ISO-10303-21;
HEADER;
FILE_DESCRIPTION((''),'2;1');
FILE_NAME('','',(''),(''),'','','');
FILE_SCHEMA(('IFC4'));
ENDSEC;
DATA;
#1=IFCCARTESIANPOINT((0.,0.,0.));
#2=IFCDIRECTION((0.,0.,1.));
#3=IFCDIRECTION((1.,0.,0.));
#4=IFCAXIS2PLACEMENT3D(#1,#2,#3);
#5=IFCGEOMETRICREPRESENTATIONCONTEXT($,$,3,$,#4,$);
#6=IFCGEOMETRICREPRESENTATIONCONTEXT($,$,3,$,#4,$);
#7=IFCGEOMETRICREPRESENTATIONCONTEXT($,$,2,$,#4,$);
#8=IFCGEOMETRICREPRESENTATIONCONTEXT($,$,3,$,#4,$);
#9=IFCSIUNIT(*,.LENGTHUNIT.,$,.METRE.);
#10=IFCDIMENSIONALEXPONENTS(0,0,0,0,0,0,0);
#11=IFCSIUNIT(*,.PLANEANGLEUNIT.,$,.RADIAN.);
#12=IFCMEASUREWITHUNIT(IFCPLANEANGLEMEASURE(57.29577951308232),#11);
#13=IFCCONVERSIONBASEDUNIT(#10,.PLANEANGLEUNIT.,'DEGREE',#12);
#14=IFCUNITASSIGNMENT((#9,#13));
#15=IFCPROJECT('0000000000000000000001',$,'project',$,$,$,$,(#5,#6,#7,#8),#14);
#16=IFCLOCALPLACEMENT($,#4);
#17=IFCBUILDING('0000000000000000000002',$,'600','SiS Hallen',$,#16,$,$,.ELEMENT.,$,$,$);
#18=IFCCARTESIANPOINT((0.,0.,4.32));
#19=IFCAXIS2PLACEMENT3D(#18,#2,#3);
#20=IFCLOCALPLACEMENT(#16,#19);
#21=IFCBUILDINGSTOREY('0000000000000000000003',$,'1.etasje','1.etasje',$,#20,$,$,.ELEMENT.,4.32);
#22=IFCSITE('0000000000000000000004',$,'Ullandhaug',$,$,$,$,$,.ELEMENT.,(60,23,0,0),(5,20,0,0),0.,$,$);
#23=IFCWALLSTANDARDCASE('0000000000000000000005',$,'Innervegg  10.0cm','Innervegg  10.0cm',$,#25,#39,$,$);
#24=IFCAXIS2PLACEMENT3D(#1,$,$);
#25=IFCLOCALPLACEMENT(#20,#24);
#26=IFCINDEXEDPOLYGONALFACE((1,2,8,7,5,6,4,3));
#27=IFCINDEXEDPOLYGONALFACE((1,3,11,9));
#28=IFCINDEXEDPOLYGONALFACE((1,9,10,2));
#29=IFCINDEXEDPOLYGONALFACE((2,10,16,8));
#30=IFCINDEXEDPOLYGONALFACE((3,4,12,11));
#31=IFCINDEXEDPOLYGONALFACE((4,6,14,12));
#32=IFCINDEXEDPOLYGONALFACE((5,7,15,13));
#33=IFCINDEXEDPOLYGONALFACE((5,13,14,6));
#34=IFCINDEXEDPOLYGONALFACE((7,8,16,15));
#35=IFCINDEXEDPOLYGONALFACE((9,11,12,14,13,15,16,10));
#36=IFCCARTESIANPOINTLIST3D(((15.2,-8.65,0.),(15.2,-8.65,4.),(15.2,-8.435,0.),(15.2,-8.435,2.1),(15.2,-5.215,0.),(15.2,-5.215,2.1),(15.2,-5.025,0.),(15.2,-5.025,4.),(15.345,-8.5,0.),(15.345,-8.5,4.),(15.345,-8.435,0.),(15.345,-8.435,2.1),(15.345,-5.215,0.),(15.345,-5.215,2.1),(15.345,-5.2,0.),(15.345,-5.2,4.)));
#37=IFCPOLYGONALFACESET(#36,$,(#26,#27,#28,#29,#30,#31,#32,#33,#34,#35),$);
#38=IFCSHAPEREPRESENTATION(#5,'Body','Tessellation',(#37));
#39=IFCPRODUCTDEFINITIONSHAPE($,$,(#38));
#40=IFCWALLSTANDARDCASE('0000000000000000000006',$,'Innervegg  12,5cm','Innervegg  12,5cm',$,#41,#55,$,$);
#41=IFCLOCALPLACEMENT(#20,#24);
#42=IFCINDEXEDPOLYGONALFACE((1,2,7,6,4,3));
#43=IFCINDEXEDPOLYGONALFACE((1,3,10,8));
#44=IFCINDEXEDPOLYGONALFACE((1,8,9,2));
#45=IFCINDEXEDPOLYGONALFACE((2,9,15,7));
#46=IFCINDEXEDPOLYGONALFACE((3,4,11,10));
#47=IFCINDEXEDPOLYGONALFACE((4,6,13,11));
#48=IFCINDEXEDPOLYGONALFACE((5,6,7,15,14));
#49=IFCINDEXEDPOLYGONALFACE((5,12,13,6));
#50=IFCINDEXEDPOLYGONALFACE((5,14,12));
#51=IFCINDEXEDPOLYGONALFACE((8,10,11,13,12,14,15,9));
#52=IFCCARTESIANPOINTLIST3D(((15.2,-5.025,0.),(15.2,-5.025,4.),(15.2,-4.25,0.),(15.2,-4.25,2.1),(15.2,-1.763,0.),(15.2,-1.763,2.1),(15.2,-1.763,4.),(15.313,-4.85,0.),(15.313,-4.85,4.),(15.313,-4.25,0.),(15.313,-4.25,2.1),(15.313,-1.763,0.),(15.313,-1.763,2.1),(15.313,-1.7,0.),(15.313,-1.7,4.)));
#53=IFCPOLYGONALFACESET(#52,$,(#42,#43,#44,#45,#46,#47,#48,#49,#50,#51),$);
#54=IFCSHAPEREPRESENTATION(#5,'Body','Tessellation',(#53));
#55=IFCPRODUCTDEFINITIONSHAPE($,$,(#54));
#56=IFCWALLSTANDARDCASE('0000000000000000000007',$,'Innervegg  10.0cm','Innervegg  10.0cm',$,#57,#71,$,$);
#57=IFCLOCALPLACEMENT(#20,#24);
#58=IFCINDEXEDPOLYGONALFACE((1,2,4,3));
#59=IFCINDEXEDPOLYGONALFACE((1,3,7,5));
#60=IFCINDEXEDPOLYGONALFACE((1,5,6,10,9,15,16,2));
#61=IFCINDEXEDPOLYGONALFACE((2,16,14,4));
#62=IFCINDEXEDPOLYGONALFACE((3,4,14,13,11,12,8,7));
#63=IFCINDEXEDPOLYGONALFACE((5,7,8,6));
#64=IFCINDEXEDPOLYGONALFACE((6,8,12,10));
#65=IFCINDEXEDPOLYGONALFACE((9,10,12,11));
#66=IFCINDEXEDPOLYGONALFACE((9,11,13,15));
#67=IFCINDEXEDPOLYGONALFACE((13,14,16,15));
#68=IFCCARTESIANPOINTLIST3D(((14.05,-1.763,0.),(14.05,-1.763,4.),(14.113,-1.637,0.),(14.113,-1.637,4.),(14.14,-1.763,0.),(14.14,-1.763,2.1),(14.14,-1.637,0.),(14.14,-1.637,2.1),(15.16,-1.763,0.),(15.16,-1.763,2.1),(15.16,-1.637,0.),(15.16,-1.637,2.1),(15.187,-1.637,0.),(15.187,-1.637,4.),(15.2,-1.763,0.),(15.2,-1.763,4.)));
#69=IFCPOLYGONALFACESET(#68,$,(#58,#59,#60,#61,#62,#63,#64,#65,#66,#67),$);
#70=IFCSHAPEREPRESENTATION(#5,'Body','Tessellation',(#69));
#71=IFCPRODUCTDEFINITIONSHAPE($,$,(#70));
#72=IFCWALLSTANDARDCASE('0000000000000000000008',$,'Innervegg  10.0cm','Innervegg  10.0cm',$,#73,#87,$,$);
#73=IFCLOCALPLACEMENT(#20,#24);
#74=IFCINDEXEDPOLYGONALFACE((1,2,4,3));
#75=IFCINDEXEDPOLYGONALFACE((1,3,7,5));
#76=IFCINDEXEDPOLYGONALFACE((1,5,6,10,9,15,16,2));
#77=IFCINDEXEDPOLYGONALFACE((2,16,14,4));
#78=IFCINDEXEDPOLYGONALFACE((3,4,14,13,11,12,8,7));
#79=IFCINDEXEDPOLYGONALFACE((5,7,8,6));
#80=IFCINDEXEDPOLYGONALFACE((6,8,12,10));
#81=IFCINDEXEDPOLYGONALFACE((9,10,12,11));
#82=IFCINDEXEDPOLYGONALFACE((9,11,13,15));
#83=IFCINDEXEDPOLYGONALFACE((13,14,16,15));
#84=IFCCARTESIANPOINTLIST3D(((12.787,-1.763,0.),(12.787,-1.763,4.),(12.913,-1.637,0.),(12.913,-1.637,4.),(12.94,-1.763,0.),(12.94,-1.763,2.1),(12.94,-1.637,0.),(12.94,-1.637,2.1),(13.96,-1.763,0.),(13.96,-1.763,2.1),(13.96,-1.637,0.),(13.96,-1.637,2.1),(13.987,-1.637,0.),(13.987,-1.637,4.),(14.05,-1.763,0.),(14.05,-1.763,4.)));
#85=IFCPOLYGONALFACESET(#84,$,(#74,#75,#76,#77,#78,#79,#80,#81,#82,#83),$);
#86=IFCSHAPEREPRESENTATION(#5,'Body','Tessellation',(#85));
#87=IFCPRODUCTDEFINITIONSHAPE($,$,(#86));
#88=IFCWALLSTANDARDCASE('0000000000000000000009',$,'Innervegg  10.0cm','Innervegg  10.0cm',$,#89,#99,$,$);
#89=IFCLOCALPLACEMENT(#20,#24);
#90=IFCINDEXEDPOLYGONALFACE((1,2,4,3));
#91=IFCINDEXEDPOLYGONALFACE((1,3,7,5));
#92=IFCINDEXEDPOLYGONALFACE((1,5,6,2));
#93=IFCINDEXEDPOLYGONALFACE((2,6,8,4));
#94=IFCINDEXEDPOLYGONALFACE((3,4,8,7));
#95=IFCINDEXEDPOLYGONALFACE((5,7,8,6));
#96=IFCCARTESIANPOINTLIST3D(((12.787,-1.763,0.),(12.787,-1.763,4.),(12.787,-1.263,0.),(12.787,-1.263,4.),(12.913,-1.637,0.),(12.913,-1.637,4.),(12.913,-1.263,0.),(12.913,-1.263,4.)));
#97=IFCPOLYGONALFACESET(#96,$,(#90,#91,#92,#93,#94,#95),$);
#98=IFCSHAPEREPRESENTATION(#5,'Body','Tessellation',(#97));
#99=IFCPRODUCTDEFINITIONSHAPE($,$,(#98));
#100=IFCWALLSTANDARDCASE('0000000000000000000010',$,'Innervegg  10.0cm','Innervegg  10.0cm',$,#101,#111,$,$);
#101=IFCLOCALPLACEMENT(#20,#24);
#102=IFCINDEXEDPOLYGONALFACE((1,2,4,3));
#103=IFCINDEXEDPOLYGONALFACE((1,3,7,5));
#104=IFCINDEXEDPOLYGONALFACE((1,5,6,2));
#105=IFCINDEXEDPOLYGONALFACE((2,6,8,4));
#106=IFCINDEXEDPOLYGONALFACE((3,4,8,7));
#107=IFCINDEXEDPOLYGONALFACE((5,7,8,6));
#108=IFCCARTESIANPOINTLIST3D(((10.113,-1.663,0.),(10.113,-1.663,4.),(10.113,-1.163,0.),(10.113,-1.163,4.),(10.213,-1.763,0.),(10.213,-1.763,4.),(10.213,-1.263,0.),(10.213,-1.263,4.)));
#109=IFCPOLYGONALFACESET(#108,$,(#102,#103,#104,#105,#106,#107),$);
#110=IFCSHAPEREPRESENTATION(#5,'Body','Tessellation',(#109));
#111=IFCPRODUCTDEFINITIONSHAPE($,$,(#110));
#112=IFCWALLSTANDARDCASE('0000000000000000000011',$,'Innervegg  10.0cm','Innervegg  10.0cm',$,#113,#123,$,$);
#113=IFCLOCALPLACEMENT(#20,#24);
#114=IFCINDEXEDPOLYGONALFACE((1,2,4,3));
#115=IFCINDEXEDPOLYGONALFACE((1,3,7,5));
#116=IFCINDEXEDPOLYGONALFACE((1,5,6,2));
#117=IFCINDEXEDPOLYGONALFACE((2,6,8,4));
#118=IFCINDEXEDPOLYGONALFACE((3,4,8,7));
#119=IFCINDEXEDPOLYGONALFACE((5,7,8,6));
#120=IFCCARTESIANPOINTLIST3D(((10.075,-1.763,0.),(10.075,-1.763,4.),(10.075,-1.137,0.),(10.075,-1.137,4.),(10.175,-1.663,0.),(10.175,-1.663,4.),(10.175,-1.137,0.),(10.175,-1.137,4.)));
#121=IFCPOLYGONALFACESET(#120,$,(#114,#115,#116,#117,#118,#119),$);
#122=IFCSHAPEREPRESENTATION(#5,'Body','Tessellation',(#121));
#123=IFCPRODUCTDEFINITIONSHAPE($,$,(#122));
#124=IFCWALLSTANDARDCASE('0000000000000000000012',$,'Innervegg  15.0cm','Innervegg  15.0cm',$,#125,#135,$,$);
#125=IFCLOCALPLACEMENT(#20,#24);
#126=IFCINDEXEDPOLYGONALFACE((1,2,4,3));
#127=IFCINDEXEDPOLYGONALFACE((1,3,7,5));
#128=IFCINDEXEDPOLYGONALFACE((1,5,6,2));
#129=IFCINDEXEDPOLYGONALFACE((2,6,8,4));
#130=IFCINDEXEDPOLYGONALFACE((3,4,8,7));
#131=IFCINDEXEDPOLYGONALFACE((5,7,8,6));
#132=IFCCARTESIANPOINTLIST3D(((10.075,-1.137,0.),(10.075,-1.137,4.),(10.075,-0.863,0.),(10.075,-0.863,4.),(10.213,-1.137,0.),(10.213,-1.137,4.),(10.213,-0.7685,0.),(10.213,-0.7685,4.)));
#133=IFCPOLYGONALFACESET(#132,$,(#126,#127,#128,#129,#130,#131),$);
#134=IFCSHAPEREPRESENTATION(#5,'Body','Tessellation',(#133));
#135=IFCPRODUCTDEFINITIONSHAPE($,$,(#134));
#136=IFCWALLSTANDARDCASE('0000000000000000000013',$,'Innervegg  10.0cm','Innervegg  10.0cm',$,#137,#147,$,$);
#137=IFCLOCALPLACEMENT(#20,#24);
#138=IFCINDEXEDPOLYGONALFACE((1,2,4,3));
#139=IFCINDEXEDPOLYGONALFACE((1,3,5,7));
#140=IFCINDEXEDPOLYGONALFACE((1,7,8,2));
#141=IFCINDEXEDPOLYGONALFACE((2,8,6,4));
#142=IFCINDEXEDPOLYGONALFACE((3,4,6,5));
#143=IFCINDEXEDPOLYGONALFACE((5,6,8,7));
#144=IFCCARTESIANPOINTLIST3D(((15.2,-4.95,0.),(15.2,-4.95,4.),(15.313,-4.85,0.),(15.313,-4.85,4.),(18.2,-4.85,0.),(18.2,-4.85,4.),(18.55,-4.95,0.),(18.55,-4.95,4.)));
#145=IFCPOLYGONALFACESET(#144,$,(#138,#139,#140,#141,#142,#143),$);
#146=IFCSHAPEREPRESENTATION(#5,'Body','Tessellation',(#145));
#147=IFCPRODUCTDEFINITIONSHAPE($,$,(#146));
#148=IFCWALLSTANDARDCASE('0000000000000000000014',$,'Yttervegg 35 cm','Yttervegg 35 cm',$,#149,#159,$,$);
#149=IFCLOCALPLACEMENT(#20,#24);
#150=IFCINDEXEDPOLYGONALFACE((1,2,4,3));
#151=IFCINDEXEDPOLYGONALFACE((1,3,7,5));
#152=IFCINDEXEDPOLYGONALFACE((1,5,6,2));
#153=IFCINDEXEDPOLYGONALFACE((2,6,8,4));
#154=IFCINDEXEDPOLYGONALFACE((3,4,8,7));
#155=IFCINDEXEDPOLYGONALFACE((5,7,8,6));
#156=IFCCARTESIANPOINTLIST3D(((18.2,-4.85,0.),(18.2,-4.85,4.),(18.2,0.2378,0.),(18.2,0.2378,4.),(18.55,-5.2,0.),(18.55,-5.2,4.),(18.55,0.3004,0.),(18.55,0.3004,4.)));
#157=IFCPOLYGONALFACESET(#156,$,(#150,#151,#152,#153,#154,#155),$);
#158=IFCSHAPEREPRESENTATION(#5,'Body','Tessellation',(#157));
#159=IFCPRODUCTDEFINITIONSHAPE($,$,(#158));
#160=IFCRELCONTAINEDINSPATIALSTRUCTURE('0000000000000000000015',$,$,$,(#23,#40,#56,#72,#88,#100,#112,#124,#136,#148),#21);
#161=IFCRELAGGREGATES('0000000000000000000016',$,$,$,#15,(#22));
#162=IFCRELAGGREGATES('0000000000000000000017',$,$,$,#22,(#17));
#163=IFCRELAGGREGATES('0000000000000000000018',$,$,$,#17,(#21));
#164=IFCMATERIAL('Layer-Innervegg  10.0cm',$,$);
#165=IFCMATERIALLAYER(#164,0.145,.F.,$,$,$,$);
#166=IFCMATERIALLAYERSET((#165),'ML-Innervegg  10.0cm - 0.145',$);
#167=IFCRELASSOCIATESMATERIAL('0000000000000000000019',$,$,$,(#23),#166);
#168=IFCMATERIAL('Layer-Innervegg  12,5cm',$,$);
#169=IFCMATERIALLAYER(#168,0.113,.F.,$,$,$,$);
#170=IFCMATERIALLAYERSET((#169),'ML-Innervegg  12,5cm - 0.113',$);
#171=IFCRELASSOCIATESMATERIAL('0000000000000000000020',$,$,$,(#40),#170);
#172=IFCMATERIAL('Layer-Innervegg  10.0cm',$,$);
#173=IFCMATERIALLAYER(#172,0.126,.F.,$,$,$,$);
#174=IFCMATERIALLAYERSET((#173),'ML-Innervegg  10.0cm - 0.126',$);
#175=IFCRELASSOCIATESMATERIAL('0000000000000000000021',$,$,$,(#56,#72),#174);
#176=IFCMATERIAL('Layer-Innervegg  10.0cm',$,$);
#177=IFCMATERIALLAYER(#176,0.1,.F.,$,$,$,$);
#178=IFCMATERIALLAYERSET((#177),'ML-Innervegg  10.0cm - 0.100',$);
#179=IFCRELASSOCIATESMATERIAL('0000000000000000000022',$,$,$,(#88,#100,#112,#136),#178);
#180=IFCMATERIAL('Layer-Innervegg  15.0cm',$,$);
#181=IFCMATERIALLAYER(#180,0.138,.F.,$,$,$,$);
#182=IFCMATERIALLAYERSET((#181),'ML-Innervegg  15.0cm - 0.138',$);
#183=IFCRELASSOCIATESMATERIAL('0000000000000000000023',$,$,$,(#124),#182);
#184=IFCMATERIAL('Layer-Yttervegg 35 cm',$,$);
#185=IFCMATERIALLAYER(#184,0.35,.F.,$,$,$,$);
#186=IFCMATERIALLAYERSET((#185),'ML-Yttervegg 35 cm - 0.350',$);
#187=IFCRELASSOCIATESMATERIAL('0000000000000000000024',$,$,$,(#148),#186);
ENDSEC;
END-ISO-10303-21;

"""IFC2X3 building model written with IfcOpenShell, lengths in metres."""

from ifc_helpers import new_model, entity, si_unit, converted_unit, frame, origin_with_axes, place, context, project, spatial, polyline, outline, extrude, material, layer, layer_set, layer_usage, element, save


model = new_model("IFC2X3")

# Units and contexts
context_of_model_1 = context(None, 3, world=origin_with_axes())
context_of_model_2 = context(None, 3, world=origin_with_axes())
context_of_model_3 = context(None, 2, world=origin_with_axes())
context_of_model_4 = context(None, 3, world=origin_with_axes())
ifc_project = project(units=[si_unit("LENGTHUNIT", "METRE"), converted_unit("PLANEANGLEUNIT", "DEGREE", entity("IfcPlaneAngleMeasure", 57.29577951308232), si_unit("PLANEANGLEUNIT", "RADIAN"), dimensions=[0, 0, 0, 0, 0, 0, 0])], contexts=[context_of_model_1, context_of_model_2, context_of_model_3, context_of_model_4])

# Site, building, storey
site = spatial("IfcSite", under=ifc_project, Name="Ullandhaug", CompositionType="ELEMENT", RefLatitude=(60, 23, 0, 0), RefLongitude=(5, 20, 0, 0), RefElevation=0.0)
building_placement = place(None, origin_with_axes())
building = spatial("IfcBuilding", under=site, at=building_placement, Name="600", Description="SiS Hallen", CompositionType="ELEMENT")
storey_placement = place(building_placement, frame((0.0, 0.0, 4.32), z_axis=(0.0, 0.0, 1.0), x_axis=(1.0, 0.0, 0.0)))
storey = spatial("IfcBuildingStorey", under=building, at=storey_placement, Name="1.etasje", Description="1.etasje", CompositionType="ELEMENT", Elevation=4.32)

# Shared definitions
ifc_material_1 = material(Name="Layer-Innervegg  10.0cm")
ifc_layer_1 = layer(ifc_material_1, 0.1, ventilated=False)
ifc_layer_set_1 = layer_set([ifc_layer_1], Name="ML-Innervegg  10.0cm - 0.100")
ifc_layer_usage_1 = layer_usage(ifc_layer_set_1, "AXIS2", "POSITIVE", 0.0)

# Walls, openings
ifc_material_2 = material(Name="Layer-Innervegg  10.0cm")
ifc_layer_2 = layer(ifc_material_2, 0.145, ventilated=False)
ifc_layer_set_2 = layer_set([ifc_layer_2], Name="ML-Innervegg  10.0cm - 0.145")
ifc_layer_usage_2 = layer_usage(ifc_layer_set_2, "AXIS2", "POSITIVE", 0.0)
wall_1_placement = place(storey_placement, frame((15.345, -8.5, 0.0), z_axis=(0.0, 0.0, 1.0), x_axis=(0.0, 1.0, 0.0)))
wall_1 = element("IfcWallStandardCase", 1, at=wall_1_placement, inside=storey, material=ifc_layer_usage_2, Name="Innervegg  10.0cm", Description="Innervegg  10.0cm", context=context_of_model_1, shape_type="SweptSolid", body=[
    extrude(outline(polyline([(0.0, 0.0), (3.3, 0.0), (3.475, 0.145), (-0.15, 0.145), (0.0, 0.0)])), frame((0.0, 0.0, 0.0), z_axis=(0.0, 0.0, 1.0), x_axis=(1.0, 0.0, 0.0)), (0.0, 0.0, 1.0), 4.0),
])
opening_1_placement = place(wall_1_placement, frame((0.065, 0.145, 0.0), z_axis=(0.0, 0.0, 1.0), x_axis=(1.0, 0.0, 0.0)))
element("IfcOpeningElement", 2, at=opening_1_placement, cuts=wall_1, context=context_of_model_1, shape_type="SweptSolid", body=[
    extrude(outline(polyline([(0.0, 0.0), (2.1, 0.0), (2.1, 3.22), (0.0, 3.22), (0.0, 0.0)])), frame((0.0, 0.0, 0.0), z_axis=(0.0, 1.0, 0.0), x_axis=(0.0, 0.0, 1.0)), (0.0, 0.0, -1.0), 0.145),
])
ifc_material_3 = material(Name="Layer-Innervegg  12,5cm")
ifc_layer_3 = layer(ifc_material_3, 0.113, ventilated=False)
ifc_layer_set_3 = layer_set([ifc_layer_3], Name="ML-Innervegg  12,5cm - 0.113")
ifc_layer_usage_3 = layer_usage(ifc_layer_set_3, "AXIS2", "POSITIVE", 0.0)
wall_2_placement = place(storey_placement, frame((15.313, -4.85, 0.0), z_axis=(0.0, 0.0, 1.0), x_axis=(0.0, 1.0, 0.0)))
wall_2 = element("IfcWallStandardCase", 3, at=wall_2_placement, inside=storey, material=ifc_layer_usage_3, Name="Innervegg  12,5cm", Description="Innervegg  12,5cm", context=context_of_model_1, shape_type="SweptSolid", body=[
    extrude(outline(polyline([(0.0, 0.0), (3.15, 0.0), (3.087, 0.113), (-0.175, 0.113), (0.0, 0.0)])), frame((0.0, 0.0, 0.0), z_axis=(0.0, 0.0, 1.0), x_axis=(1.0, 0.0, 0.0)), (0.0, 0.0, 1.0), 4.0),
])
opening_2_placement = place(wall_2_placement, frame((0.6, 0.113, 0.0), z_axis=(0.0, 0.0, 1.0), x_axis=(1.0, 0.0, 0.0)))
element("IfcOpeningElement", 4, at=opening_2_placement, cuts=wall_2, context=context_of_model_1, shape_type="SweptSolid", body=[
    extrude(outline(polyline([(0.0, 0.0), (2.1, 0.0), (2.1, 2.487), (0.0, 2.487), (0.0, 0.0)])), frame((0.0, 0.0, 0.0), z_axis=(0.0, 1.0, 0.0), x_axis=(0.0, 0.0, 1.0)), (0.0, 0.0, -1.0), 0.113),
])
ifc_material_4 = material(Name="Layer-Innervegg  10.0cm")
ifc_layer_4 = layer(ifc_material_4, 0.126, ventilated=False)
ifc_layer_set_4 = layer_set([ifc_layer_4], Name="ML-Innervegg  10.0cm - 0.126")
ifc_layer_usage_4 = layer_usage(ifc_layer_set_4, "AXIS2", "POSITIVE", 0.0)
wall_3_placement = place(storey_placement, frame((15.187, -1.637, 0.0), z_axis=(0.0, 0.0, 1.0), x_axis=(-1.0, 0.0, 0.0)))
wall_3 = element("IfcWallStandardCase", 5, at=wall_3_placement, inside=storey, material=ifc_layer_usage_4, Name="Innervegg  10.0cm", Description="Innervegg  10.0cm", context=context_of_model_1, shape_type="SweptSolid", body=[
    extrude(outline(polyline([(0.0, 0.0), (1.074, 0.0), (1.137, 0.126), (-0.013, 0.126), (0.0, 0.0)])), frame((0.0, 0.0, 0.0), z_axis=(0.0, 0.0, 1.0), x_axis=(1.0, 0.0, 0.0)), (0.0, 0.0, 1.0), 4.0),
])
opening_3_placement = place(wall_3_placement, frame((0.027, 0.126, 0.0), z_axis=(0.0, 0.0, 1.0), x_axis=(1.0, 0.0, 0.0)))
element("IfcOpeningElement", 6, at=opening_3_placement, cuts=wall_3, context=context_of_model_1, shape_type="SweptSolid", body=[
    extrude(outline(polyline([(0.0, 0.0), (2.1, 0.0), (2.1, 1.02), (0.0, 1.02), (0.0, 0.0)])), frame((0.0, 0.0, 0.0), z_axis=(0.0, 1.0, 0.0), x_axis=(0.0, 0.0, 1.0)), (0.0, 0.0, -1.0), 0.126),
])
wall_4_placement = place(storey_placement, frame((13.987, -1.637, 0.0), z_axis=(0.0, 0.0, 1.0), x_axis=(-1.0, 0.0, 0.0)))
wall_4 = element("IfcWallStandardCase", 7, at=wall_4_placement, inside=storey, material=ifc_layer_usage_4, Name="Innervegg  10.0cm", Description="Innervegg  10.0cm", context=context_of_model_1, shape_type="SweptSolid", body=[
    extrude(outline(polyline([(0.0, 0.0), (1.074, 0.0), (1.2, 0.126), (-0.063, 0.126), (0.0, 0.0)])), frame((0.0, 0.0, 0.0), z_axis=(0.0, 0.0, 1.0), x_axis=(1.0, 0.0, 0.0)), (0.0, 0.0, 1.0), 4.0),
])
opening_4_placement = place(wall_4_placement, frame((0.027, 0.126, 0.0), z_axis=(0.0, 0.0, 1.0), x_axis=(1.0, 0.0, 0.0)))
element("IfcOpeningElement", 8, at=opening_4_placement, cuts=wall_4, context=context_of_model_1, shape_type="SweptSolid", body=[
    extrude(outline(polyline([(0.0, 0.0), (2.1, 0.0), (2.1, 1.02), (0.0, 1.02), (0.0, 0.0)])), frame((0.0, 0.0, 0.0), z_axis=(0.0, 1.0, 0.0), x_axis=(0.0, 0.0, 1.0)), (0.0, 0.0, -1.0), 0.126),
])

# Walls
wall_5_placement = place(storey_placement, frame((12.913, -1.637, 0.0), z_axis=(0.0, 0.0, 1.0), x_axis=(0.0, 1.0, 0.0)))
element("IfcWallStandardCase", 9, at=wall_5_placement, inside=storey, material=ifc_layer_usage_1, Name="Innervegg  10.0cm", Description="Innervegg  10.0cm", context=context_of_model_1, shape_type="SweptSolid", body=[
    extrude(outline(polyline([(0.0, 0.0), (0.374, 0.0), (0.374, 0.126), (-0.126, 0.126), (0.0, 0.0)])), frame((0.0, 0.0, 0.0), z_axis=(0.0, 0.0, 1.0), x_axis=(1.0, 0.0, 0.0)), (0.0, 0.0, 1.0), 4.0),
])
wall_6_placement = place(storey_placement, frame((10.113, -1.163, 0.0), z_axis=(0.0, 0.0, 1.0), x_axis=(0.0, -1.0, 0.0)))
element("IfcWallStandardCase", 10, at=wall_6_placement, inside=storey, material=ifc_layer_usage_1, Name="Innervegg  10.0cm", Description="Innervegg  10.0cm", context=context_of_model_1, shape_type="SweptSolid", body=[
    extrude(outline(polyline([(0.0, 0.0), (0.5, 0.0), (0.6, 0.1), (0.1, 0.1), (0.0, 0.0)])), frame((0.0, 0.0, 0.0), z_axis=(0.0, 0.0, 1.0), x_axis=(1.0, 0.0, 0.0)), (0.0, 0.0, 1.0), 4.0),
])
wall_7_placement = place(storey_placement, frame((10.175, -1.663, 0.0), z_axis=(0.0, 0.0, 1.0), x_axis=(0.0, 1.0, 0.0)))
element("IfcWallStandardCase", 11, at=wall_7_placement, inside=storey, material=ifc_layer_usage_1, Name="Innervegg  10.0cm", Description="Innervegg  10.0cm", context=context_of_model_1, shape_type="SweptSolid", body=[
    extrude(outline(polyline([(0.0, 0.0), (0.526, 0.0), (0.526, 0.1), (-0.1, 0.1), (0.0, 0.0)])), frame((0.0, 0.0, 0.0), z_axis=(0.0, 0.0, 1.0), x_axis=(1.0, 0.0, 0.0)), (0.0, 0.0, 1.0), 4.0),
])
ifc_material_5 = material(Name="Layer-Innervegg  15.0cm")
ifc_layer_5 = layer(ifc_material_5, 0.138, ventilated=False)
ifc_layer_set_5 = layer_set([ifc_layer_5], Name="ML-Innervegg  15.0cm - 0.138")
ifc_layer_usage_5 = layer_usage(ifc_layer_set_5, "AXIS2", "POSITIVE", 0.0)
wall_8_placement = place(storey_placement, frame((10.213, -1.137, 0.0), z_axis=(0.0, 0.0, 1.0), x_axis=(0.0, 1.0, 0.0)))
element("IfcWallStandardCase", 12, at=wall_8_placement, inside=storey, material=ifc_layer_usage_5, Name="Innervegg  15.0cm", Description="Innervegg  15.0cm", context=context_of_model_1, shape_type="SweptSolid", body=[
    extrude(outline(polyline([(0.0, 0.0), (0.3685, 0.0), (0.274, 0.138), (0.0, 0.138), (0.0, 0.0)])), frame((0.0, 0.0, 0.0), z_axis=(0.0, 0.0, 1.0), x_axis=(1.0, 0.0, 0.0)), (0.0, 0.0, 1.0), 4.0),
])
wall_9_placement = place(storey_placement, frame((15.2, -4.95, 0.0), z_axis=(0.0, 0.0, 1.0), x_axis=(1.0, 0.0, 0.0)))
element("IfcWallStandardCase", 13, at=wall_9_placement, inside=storey, material=ifc_layer_usage_1, Name="Innervegg  10.0cm", Description="Innervegg  10.0cm", context=context_of_model_1, shape_type="SweptSolid", body=[
    extrude(outline(polyline([(0.0, 0.0), (3.35, 0.0), (3.0, 0.1), (0.113, 0.1), (0.0, 0.0)])), origin_with_axes(), (0.0, 0.0, 1.0), 4.0),
])
ifc_material_6 = material(Name="Layer-Yttervegg 35 cm")
ifc_layer_6 = layer(ifc_material_6, 0.35, ventilated=False)
ifc_layer_set_6 = layer_set([ifc_layer_6], Name="ML-Yttervegg 35 cm - 0.350")
ifc_layer_usage_6 = layer_usage(ifc_layer_set_6, "AXIS2", "POSITIVE", 0.0)
wall_10_placement = place(storey_placement, frame((18.55, -5.2, 0.0), z_axis=(0.0, 0.0, 1.0), x_axis=(0.0, 1.0, 0.0)))
element("IfcWallStandardCase", 14, at=wall_10_placement, inside=storey, material=ifc_layer_usage_6, Name="Yttervegg 35 cm", Description="Yttervegg 35 cm", context=context_of_model_1, shape_type="SweptSolid", body=[
    extrude(outline(polyline([(0.0, 0.0), (5.5004, 0.0), (5.4378, 0.35), (0.35, 0.35), (0.0, 0.0)])), frame((0.0, 0.0, 0.0), z_axis=(0.0, 0.0, 1.0), x_axis=(1.0, 0.0, 0.0)), (0.0, 0.0, 1.0), 4.0),
])

save(model, "model.ifc")
